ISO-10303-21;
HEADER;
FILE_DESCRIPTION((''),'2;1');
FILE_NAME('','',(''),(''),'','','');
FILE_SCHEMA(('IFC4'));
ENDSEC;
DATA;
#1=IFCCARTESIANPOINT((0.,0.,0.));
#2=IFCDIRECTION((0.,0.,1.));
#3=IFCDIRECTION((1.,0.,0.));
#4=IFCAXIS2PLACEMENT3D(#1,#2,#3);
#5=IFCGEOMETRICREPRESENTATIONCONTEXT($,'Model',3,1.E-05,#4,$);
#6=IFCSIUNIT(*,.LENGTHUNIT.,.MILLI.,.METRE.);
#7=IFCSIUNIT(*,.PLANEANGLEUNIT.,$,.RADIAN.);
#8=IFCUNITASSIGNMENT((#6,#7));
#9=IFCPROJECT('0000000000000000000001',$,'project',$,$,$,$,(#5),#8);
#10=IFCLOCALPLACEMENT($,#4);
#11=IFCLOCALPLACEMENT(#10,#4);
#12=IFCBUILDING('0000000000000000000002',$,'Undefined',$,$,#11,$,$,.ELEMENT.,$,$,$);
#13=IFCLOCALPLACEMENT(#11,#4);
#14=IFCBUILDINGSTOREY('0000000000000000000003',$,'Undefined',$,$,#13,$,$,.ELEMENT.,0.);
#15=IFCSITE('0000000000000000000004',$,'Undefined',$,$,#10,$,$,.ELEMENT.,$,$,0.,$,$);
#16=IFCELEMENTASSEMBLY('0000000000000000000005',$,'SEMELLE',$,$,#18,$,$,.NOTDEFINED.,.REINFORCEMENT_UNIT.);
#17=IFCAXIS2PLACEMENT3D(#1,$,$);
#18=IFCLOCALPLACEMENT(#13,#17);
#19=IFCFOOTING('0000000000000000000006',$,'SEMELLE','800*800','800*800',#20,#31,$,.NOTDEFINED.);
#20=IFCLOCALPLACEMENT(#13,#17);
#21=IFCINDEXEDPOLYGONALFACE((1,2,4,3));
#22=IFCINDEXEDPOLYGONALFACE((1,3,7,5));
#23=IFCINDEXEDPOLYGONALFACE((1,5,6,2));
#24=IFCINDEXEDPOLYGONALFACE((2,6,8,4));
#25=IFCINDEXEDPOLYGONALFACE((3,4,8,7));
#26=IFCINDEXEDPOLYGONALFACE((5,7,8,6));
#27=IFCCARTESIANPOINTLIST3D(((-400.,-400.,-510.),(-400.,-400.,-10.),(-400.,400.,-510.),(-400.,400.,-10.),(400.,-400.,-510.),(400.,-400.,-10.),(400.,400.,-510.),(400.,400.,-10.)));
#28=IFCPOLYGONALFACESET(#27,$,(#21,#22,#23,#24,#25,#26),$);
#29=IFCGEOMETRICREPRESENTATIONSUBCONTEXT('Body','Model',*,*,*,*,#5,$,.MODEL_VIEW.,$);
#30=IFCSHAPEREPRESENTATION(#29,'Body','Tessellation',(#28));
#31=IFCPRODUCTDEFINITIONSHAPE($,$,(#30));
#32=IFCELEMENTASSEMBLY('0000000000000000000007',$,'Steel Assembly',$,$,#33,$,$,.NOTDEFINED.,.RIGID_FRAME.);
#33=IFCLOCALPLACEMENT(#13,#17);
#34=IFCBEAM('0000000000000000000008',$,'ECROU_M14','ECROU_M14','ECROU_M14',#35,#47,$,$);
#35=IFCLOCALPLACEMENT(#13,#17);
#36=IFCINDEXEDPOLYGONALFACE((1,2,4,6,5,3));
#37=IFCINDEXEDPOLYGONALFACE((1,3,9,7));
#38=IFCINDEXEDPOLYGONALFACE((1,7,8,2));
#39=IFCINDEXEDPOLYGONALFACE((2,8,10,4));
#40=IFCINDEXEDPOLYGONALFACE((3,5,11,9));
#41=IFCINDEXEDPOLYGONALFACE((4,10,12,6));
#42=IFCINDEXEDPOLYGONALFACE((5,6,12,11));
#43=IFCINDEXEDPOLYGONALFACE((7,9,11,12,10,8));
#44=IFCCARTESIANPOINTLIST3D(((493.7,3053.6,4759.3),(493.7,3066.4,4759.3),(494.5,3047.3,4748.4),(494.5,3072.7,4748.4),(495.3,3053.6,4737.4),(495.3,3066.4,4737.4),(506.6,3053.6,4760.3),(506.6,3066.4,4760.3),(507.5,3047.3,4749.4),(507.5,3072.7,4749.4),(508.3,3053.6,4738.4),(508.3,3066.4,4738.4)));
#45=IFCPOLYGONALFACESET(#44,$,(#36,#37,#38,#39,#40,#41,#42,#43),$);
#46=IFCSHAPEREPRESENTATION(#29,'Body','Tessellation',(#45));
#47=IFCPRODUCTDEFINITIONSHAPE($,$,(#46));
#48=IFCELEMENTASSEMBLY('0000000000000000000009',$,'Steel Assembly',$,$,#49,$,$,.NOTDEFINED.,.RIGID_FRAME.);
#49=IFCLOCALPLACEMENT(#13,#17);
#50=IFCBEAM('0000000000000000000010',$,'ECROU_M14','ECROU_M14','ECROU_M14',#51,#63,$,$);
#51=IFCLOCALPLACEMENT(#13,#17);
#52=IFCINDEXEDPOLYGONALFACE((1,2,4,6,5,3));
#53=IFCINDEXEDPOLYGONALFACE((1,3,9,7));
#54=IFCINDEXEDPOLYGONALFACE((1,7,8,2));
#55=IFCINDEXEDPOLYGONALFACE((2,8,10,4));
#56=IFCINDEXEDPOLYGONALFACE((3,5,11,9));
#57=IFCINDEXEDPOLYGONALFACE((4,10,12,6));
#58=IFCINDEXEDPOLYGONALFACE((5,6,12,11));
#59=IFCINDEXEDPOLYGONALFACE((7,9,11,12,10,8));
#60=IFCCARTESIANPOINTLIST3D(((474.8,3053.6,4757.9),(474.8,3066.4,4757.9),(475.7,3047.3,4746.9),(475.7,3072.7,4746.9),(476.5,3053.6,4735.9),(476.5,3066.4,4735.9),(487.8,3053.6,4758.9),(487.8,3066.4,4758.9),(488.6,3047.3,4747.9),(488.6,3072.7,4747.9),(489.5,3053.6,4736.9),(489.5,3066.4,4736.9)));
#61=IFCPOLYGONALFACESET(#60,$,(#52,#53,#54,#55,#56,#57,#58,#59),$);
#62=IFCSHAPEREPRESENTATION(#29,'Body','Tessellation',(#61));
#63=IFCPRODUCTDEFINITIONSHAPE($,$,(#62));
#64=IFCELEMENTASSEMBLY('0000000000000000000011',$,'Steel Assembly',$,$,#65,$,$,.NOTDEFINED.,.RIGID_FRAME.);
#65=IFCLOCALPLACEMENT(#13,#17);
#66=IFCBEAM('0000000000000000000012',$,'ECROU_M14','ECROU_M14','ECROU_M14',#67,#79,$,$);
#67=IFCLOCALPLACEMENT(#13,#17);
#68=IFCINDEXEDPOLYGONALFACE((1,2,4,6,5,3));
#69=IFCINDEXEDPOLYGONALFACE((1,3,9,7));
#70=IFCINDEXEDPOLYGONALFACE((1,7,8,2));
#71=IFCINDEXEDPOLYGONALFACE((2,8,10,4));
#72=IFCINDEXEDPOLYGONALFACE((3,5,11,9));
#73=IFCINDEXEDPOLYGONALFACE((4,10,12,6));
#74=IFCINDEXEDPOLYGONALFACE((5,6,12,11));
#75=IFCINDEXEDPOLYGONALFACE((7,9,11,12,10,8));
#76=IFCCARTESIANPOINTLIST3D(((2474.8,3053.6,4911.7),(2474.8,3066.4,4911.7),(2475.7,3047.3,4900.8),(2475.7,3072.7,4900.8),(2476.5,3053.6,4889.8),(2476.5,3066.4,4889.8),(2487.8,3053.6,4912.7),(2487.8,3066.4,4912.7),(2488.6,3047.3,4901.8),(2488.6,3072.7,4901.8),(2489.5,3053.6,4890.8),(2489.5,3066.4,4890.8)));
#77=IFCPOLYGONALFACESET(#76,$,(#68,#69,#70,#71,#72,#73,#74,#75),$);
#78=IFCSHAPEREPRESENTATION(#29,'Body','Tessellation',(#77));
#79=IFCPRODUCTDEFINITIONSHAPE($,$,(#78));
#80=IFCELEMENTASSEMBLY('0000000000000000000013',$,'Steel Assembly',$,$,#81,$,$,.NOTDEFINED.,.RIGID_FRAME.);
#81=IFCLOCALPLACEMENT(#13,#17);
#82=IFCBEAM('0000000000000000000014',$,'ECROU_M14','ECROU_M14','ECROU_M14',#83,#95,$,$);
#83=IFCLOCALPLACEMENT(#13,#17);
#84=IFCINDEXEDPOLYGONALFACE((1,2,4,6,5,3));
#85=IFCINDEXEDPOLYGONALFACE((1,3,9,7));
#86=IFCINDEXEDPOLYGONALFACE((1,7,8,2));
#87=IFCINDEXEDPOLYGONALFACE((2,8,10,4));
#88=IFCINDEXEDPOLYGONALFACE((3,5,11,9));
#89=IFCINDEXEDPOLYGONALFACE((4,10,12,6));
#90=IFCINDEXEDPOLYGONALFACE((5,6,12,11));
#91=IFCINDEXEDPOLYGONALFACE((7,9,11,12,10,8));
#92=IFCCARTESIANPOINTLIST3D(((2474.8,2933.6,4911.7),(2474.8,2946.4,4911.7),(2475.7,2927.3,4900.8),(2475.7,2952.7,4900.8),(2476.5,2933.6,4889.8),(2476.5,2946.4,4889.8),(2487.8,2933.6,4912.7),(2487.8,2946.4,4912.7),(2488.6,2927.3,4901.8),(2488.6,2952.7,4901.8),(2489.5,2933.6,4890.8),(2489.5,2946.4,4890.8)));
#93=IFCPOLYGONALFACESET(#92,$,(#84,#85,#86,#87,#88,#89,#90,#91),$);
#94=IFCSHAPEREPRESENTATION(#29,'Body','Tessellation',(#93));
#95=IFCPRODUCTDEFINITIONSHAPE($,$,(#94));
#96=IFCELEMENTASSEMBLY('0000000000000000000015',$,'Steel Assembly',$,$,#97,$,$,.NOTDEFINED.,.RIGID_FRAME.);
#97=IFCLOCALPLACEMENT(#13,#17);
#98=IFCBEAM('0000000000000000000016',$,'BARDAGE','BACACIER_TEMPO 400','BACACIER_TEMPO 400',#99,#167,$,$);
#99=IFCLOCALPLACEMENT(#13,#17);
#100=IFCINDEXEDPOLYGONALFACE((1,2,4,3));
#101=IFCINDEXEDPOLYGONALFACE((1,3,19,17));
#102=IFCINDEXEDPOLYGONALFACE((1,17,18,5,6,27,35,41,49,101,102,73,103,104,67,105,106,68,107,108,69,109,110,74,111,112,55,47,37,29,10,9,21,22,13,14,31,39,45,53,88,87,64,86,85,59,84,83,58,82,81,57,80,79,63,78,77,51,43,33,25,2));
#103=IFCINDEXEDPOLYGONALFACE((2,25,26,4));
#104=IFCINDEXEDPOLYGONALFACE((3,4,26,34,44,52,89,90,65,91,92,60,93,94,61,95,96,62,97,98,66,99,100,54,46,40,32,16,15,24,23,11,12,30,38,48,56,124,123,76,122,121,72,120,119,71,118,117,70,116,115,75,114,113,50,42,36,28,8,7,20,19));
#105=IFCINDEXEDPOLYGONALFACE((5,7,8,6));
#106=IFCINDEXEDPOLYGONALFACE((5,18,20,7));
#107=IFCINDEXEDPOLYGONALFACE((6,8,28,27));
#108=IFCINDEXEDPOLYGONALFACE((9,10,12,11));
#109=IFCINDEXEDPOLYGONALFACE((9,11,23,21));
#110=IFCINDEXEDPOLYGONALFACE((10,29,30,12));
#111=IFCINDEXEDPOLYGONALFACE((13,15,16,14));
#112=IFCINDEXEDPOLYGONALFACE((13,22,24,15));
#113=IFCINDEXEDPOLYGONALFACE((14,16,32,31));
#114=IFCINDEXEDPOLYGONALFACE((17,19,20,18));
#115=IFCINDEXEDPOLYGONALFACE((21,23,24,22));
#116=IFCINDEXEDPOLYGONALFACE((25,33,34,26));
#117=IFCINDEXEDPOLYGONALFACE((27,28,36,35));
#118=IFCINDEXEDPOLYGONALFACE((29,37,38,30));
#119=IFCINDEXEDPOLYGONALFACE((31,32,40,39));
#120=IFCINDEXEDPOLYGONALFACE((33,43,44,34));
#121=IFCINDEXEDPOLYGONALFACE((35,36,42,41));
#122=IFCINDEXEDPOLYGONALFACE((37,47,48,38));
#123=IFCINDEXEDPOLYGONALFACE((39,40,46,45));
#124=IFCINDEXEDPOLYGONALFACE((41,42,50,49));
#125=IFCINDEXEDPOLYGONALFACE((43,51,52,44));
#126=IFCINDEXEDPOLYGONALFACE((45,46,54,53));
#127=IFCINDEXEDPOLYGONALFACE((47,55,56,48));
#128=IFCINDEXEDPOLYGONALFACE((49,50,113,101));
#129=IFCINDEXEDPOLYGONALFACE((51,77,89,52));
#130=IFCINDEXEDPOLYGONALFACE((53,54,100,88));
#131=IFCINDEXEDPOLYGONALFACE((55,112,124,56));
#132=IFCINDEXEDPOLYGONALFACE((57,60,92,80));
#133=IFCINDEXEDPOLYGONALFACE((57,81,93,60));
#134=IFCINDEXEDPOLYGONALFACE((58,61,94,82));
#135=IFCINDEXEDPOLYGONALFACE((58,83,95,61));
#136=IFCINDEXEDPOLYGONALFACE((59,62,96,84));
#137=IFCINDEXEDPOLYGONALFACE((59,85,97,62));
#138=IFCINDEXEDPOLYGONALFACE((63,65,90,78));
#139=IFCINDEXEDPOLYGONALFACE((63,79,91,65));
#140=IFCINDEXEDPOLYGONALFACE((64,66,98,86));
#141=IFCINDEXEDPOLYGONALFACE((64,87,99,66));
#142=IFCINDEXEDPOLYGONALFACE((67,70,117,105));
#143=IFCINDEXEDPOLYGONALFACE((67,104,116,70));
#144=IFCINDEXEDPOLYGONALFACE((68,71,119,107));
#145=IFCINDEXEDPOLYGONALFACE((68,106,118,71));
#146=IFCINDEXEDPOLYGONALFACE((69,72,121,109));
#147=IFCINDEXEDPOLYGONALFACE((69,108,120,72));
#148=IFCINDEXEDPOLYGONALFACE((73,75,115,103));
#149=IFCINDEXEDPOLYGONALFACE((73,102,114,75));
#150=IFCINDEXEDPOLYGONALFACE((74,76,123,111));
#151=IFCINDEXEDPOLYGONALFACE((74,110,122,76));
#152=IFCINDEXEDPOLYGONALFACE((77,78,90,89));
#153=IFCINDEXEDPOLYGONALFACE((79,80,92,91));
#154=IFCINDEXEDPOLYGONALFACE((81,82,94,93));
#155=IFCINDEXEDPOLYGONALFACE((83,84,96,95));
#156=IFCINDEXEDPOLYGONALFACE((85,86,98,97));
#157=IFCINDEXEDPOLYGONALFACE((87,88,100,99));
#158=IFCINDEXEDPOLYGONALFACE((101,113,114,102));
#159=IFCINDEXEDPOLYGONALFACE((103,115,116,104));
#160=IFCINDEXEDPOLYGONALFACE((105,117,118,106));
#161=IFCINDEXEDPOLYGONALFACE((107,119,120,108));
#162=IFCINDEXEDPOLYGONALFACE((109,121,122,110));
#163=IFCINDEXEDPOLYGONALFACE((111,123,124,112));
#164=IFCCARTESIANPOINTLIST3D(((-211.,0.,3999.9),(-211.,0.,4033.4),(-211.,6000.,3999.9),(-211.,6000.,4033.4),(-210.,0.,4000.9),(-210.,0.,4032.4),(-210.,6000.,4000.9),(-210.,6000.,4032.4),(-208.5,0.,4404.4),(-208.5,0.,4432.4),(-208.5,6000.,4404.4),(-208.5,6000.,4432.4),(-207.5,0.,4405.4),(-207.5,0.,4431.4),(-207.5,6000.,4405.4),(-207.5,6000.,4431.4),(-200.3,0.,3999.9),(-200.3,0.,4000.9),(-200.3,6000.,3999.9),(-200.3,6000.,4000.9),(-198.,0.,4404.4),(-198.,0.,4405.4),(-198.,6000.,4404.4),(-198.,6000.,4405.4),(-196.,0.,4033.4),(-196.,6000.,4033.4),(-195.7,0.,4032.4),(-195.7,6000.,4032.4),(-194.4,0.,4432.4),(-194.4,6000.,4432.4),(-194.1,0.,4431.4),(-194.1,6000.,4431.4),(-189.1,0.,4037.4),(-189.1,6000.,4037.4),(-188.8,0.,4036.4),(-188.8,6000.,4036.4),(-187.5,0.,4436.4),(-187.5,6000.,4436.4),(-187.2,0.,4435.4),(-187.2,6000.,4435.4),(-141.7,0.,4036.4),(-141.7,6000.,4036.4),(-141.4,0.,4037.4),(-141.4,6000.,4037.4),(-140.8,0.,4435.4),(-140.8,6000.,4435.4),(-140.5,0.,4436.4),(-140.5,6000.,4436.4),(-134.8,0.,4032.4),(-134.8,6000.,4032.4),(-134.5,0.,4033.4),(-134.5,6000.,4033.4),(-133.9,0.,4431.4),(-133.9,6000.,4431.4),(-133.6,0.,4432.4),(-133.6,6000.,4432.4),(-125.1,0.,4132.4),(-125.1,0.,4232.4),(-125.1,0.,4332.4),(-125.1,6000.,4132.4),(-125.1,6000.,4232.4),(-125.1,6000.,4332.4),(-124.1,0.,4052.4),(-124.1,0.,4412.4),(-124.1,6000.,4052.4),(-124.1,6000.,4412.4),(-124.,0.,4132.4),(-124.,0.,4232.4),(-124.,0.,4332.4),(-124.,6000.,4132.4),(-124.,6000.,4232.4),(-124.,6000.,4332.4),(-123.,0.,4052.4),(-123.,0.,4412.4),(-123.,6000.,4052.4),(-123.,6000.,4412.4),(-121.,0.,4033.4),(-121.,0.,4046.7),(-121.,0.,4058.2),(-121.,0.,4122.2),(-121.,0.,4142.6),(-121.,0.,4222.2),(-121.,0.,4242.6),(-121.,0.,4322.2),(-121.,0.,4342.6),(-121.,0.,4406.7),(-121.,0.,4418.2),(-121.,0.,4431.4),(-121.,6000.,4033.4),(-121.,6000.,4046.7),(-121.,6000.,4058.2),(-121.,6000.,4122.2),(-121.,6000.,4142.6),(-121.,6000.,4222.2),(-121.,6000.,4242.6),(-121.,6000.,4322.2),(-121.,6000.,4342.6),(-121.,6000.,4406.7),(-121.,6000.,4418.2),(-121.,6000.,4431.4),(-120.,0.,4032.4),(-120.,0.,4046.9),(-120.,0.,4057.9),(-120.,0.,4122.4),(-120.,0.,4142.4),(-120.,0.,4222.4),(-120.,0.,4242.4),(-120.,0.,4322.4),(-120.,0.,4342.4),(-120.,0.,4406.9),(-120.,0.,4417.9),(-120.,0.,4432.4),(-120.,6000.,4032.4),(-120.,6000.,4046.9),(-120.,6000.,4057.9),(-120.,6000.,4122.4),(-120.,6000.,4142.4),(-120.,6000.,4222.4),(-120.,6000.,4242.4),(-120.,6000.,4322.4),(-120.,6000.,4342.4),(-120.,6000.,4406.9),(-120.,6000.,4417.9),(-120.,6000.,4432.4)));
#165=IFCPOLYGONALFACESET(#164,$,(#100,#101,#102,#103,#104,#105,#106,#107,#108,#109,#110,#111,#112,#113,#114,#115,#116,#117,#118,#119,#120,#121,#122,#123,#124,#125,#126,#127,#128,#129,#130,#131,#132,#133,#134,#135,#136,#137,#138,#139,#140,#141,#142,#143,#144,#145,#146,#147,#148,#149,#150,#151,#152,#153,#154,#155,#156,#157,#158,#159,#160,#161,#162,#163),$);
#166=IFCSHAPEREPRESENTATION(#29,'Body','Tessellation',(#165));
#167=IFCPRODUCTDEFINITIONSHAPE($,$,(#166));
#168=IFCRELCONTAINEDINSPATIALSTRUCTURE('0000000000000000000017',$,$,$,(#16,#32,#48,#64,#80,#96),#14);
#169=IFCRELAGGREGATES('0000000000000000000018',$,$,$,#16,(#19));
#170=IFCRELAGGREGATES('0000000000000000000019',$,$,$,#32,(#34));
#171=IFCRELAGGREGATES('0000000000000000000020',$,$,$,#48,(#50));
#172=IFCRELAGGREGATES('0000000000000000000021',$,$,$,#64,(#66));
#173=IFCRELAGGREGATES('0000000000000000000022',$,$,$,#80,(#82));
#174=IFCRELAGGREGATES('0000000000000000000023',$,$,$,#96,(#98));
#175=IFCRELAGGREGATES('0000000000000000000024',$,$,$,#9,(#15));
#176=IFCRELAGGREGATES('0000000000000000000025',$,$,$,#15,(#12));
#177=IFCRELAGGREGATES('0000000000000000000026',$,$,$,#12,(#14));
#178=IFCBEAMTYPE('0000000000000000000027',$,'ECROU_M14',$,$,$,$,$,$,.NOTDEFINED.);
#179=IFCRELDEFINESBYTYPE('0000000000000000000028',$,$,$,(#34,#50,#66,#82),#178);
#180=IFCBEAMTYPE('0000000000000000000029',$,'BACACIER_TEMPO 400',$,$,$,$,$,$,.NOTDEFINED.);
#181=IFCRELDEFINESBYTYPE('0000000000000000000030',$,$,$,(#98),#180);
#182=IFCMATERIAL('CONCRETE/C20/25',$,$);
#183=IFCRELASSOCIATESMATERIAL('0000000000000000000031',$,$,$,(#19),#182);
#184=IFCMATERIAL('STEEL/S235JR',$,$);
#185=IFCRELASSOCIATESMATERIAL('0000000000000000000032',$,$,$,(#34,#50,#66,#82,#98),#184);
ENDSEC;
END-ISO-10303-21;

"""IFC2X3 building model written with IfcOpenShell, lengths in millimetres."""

from ifc_helpers import new_model, si_unit, frame, origin_with_axes, origin_2d_with_axis, place, context, subcontext, project, spatial, polyline, rectangle, outline, extrude, material, type_object, element, aggregate, save


model = new_model("IFC2X3")

# Units and contexts
model_context = context("Model", 3, precision=1e-05, world=origin_with_axes())
body_context = subcontext(model_context, "Body", "Model", "MODEL_VIEW")
ifc_project = project(units=[si_unit("LENGTHUNIT", "METRE", prefix="MILLI"), si_unit("PLANEANGLEUNIT", "RADIAN")], contexts=[model_context])

# Site, building, storey
site_placement = place(None, origin_with_axes())
site = spatial("IfcSite", under=ifc_project, at=site_placement, Name="Undefined", CompositionType="ELEMENT", RefElevation=0.0)
building_placement = place(site_placement, origin_with_axes())
building = spatial("IfcBuilding", under=site, at=building_placement, Name="Undefined", CompositionType="ELEMENT")
storey_placement = place(building_placement, origin_with_axes())
storey = spatial("IfcBuildingStorey", under=building, at=storey_placement, Name="Undefined", CompositionType="ELEMENT", Elevation=0.0)

# Element assembly, footing
assembly_1_placement = place(storey_placement, origin_with_axes())
assembly_1 = element("IfcElementAssembly", 1, at=assembly_1_placement, inside=storey, Name="SEMELLE", AssemblyPlace="NOTDEFINED", PredefinedType="REINFORCEMENT_UNIT")
ifc_material_1 = material(Name="CONCRETE/C20/25")
footing_placement = place(assembly_1_placement, frame((0.0, 0.0, -510.0), z_axis=(0.0, -1.0, 0.0), x_axis=(0.0, 0.0, 1.0)))
footing = element("IfcFooting", 2, at=footing_placement, material=ifc_material_1, Name="SEMELLE", Description="800*800", ObjectType="800*800", PredefinedType="NOTDEFINED", context=body_context, shape_type="SweptSolid", body=[
    extrude(rectangle(XDim=800.0, YDim=800.0, at=origin_2d_with_axis()), frame((500.0, 0.0, 0.0), z_axis=(-1.0, 0.0, 0.0), x_axis=(0.0, -1.0, 0.0)), (0.0, 0.0, 1.0), 500.0),
])
aggregate(assembly_1, [footing])

# Element assemblies, beams
assembly_2_placement = place(storey_placement, origin_with_axes())
assembly_2 = element("IfcElementAssembly", 3, at=assembly_2_placement, inside=storey, Name="Steel Assembly", AssemblyPlace="NOTDEFINED", PredefinedType="RIGID_FRAME")
ifc_material_2 = material(Name="STEEL/S235JR")
beam_type_1 = type_object("IfcBeamType", Name="ECROU_M14", PredefinedType="NOTDEFINED")
beam_1_placement = place(assembly_2_placement, frame((507.5, 3060.0, 4749.4), z_axis=(-0.076696, 0.0, 0.997054), x_axis=(-0.997054, 0.0, -0.076696)))
beam_1 = element("IfcBeam", 4, at=beam_1_placement, type_object=beam_type_1, material=ifc_material_2, Name="ECROU_M14", Description="ECROU_M14", ObjectType="ECROU_M14", context=body_context, shape_type="SweptSolid", body=[
    extrude(outline(polyline([(12.7, 0.0), (6.4, -11.0), (-6.4, -11.0), (-12.7, 0.0), (-6.4, 11.0), (6.4, 11.0), (12.7, 0.0)])), frame((13.0, 0.0, 0.0), z_axis=(-1.0, 0.0, 0.0), x_axis=(0.0, -1.0, 0.0)), (0.0, 0.0, 1.0), 13.0),
])
aggregate(assembly_2, [beam_1])
assembly_3_placement = place(storey_placement, origin_with_axes())
assembly_3 = element("IfcElementAssembly", 5, at=assembly_3_placement, inside=storey, Name="Steel Assembly", AssemblyPlace="NOTDEFINED", PredefinedType="RIGID_FRAME")
beam_2_placement = place(assembly_3_placement, frame((488.6, 3060.0, 4747.9), z_axis=(-0.076696, 0.0, 0.997054), x_axis=(-0.997054, 0.0, -0.076696)))
beam_2 = element("IfcBeam", 6, at=beam_2_placement, type_object=beam_type_1, material=ifc_material_2, Name="ECROU_M14", Description="ECROU_M14", ObjectType="ECROU_M14", context=body_context, shape_type="SweptSolid", body=[
    extrude(outline(polyline([(12.7, 0.0), (6.4, -11.0), (-6.4, -11.0), (-12.7, 0.0), (-6.4, 11.0), (6.4, 11.0), (12.7, 0.0)])), frame((13.0, 0.0, 0.0), z_axis=(-1.0, 0.0, 0.0), x_axis=(0.0, -1.0, 0.0)), (0.0, 0.0, 1.0), 13.0),
])
aggregate(assembly_3, [beam_2])
assembly_4_placement = place(storey_placement, origin_with_axes())
assembly_4 = element("IfcElementAssembly", 7, at=assembly_4_placement, inside=storey, Name="Steel Assembly", AssemblyPlace="NOTDEFINED", PredefinedType="RIGID_FRAME")
beam_3_placement = place(assembly_4_placement, frame((2488.6, 3060.0, 4901.8), z_axis=(-0.076696, 0.0, 0.997054), x_axis=(-0.997054, 0.0, -0.076696)))
beam_3 = element("IfcBeam", 8, at=beam_3_placement, type_object=beam_type_1, material=ifc_material_2, Name="ECROU_M14", Description="ECROU_M14", ObjectType="ECROU_M14", context=body_context, shape_type="SweptSolid", body=[
    extrude(outline(polyline([(12.7, 0.0), (6.4, -11.0), (-6.4, -11.0), (-12.7, 0.0), (-6.4, 11.0), (6.4, 11.0), (12.7, 0.0)])), frame((13.0, 0.0, 0.0), z_axis=(-1.0, 0.0, 0.0), x_axis=(0.0, -1.0, 0.0)), (0.0, 0.0, 1.0), 13.0),
])
aggregate(assembly_4, [beam_3])
assembly_5_placement = place(storey_placement, origin_with_axes())
assembly_5 = element("IfcElementAssembly", 9, at=assembly_5_placement, inside=storey, Name="Steel Assembly", AssemblyPlace="NOTDEFINED", PredefinedType="RIGID_FRAME")
beam_4_placement = place(assembly_5_placement, frame((2488.6, 2940.0, 4901.8), z_axis=(-0.076696, 0.0, 0.997054), x_axis=(-0.997054, 0.0, -0.076696)))
beam_4 = element("IfcBeam", 10, at=beam_4_placement, type_object=beam_type_1, material=ifc_material_2, Name="ECROU_M14", Description="ECROU_M14", ObjectType="ECROU_M14", context=body_context, shape_type="SweptSolid", body=[
    extrude(outline(polyline([(12.7, 0.0), (6.4, -11.0), (-6.4, -11.0), (-12.7, 0.0), (-6.4, 11.0), (6.4, 11.0), (12.7, 0.0)])), frame((13.0, 0.0, 0.0), z_axis=(-1.0, 0.0, 0.0), x_axis=(0.0, -1.0, 0.0)), (0.0, 0.0, 1.0), 13.0),
])
aggregate(assembly_5, [beam_4])
beam_type_2 = type_object("IfcBeamType", Name="BACACIER_TEMPO 400", PredefinedType="NOTDEFINED")
assembly_6_placement = place(storey_placement, origin_with_axes())
assembly_6 = element("IfcElementAssembly", 11, at=assembly_6_placement, inside=storey, Name="Steel Assembly", AssemblyPlace="NOTDEFINED", PredefinedType="RIGID_FRAME")
beam_5_placement = place(assembly_6_placement, frame((-165.5, 0.0, 4218.2), z_axis=(-1.0, 0.0, 0.0), x_axis=(0.0, 1.0, 0.0)))
beam_5 = element("IfcBeam", 12, at=beam_5_placement, type_object=beam_type_2, material=ifc_material_2, Name="BARDAGE", Description="BACACIER_TEMPO 400", ObjectType="BACACIER_TEMPO 400", context=body_context, shape_type="SweptSolid", body=[
    extrude(outline(polyline([(218.2, -25.0), (214.2, -31.9), (214.2, -45.5), (199.8, -45.5), (194.2, -42.5), (188.8, -45.5), (124.2, -45.5), (114.2, -41.5), (104.2, -45.5), (24.2, -45.5), (14.2, -41.5), (4.2, -45.5), (-75.8, -45.5), (-85.8, -41.5), (-95.8, -45.5), (-160.2, -45.5), (-165.8, -42.5), (-171.2, -45.5), (-185.8, -45.5), (-185.8, -30.7), (-181.8, -23.8), (-181.8, 23.3), (-185.8, 30.2), (-185.8, 44.5), (-217.2, 44.5), (-217.2, 34.8), (-218.2, 34.8), (-218.2, 45.5), (-184.8, 45.5), (-184.8, 30.5), (-180.8, 23.6), (-180.8, -24.1), (-184.8, -31.0), (-184.8, -44.5), (-171.5, -44.5), (-165.8, -41.4), (-160.0, -44.5), (-95.9, -44.5), (-85.8, -40.4), (-75.6, -44.5), (4.1, -44.5), (14.2, -40.4), (24.4, -44.5), (104.1, -44.5), (114.2, -40.4), (124.4, -44.5), (188.5, -44.5), (194.2, -41.4), (200.0, -44.5), (213.2, -44.5), (213.2, -31.6), (217.2, -24.7), (217.2, 21.7), (213.2, 28.6), (213.2, 42.0), (187.2, 42.0), (187.2, 32.5), (186.2, 32.5), (186.2, 43.0), (214.2, 43.0), (214.2, 28.9), (218.2, 22.0), (218.2, -25.0)])), frame((6000.0, 0.0, 0.0), z_axis=(-1.0, 0.0, 0.0), x_axis=(0.0, -1.0, 0.0)), (0.0, 0.0, 1.0), 6000.0),
])
aggregate(assembly_6, [beam_5])

save(model, "model.ifc")
